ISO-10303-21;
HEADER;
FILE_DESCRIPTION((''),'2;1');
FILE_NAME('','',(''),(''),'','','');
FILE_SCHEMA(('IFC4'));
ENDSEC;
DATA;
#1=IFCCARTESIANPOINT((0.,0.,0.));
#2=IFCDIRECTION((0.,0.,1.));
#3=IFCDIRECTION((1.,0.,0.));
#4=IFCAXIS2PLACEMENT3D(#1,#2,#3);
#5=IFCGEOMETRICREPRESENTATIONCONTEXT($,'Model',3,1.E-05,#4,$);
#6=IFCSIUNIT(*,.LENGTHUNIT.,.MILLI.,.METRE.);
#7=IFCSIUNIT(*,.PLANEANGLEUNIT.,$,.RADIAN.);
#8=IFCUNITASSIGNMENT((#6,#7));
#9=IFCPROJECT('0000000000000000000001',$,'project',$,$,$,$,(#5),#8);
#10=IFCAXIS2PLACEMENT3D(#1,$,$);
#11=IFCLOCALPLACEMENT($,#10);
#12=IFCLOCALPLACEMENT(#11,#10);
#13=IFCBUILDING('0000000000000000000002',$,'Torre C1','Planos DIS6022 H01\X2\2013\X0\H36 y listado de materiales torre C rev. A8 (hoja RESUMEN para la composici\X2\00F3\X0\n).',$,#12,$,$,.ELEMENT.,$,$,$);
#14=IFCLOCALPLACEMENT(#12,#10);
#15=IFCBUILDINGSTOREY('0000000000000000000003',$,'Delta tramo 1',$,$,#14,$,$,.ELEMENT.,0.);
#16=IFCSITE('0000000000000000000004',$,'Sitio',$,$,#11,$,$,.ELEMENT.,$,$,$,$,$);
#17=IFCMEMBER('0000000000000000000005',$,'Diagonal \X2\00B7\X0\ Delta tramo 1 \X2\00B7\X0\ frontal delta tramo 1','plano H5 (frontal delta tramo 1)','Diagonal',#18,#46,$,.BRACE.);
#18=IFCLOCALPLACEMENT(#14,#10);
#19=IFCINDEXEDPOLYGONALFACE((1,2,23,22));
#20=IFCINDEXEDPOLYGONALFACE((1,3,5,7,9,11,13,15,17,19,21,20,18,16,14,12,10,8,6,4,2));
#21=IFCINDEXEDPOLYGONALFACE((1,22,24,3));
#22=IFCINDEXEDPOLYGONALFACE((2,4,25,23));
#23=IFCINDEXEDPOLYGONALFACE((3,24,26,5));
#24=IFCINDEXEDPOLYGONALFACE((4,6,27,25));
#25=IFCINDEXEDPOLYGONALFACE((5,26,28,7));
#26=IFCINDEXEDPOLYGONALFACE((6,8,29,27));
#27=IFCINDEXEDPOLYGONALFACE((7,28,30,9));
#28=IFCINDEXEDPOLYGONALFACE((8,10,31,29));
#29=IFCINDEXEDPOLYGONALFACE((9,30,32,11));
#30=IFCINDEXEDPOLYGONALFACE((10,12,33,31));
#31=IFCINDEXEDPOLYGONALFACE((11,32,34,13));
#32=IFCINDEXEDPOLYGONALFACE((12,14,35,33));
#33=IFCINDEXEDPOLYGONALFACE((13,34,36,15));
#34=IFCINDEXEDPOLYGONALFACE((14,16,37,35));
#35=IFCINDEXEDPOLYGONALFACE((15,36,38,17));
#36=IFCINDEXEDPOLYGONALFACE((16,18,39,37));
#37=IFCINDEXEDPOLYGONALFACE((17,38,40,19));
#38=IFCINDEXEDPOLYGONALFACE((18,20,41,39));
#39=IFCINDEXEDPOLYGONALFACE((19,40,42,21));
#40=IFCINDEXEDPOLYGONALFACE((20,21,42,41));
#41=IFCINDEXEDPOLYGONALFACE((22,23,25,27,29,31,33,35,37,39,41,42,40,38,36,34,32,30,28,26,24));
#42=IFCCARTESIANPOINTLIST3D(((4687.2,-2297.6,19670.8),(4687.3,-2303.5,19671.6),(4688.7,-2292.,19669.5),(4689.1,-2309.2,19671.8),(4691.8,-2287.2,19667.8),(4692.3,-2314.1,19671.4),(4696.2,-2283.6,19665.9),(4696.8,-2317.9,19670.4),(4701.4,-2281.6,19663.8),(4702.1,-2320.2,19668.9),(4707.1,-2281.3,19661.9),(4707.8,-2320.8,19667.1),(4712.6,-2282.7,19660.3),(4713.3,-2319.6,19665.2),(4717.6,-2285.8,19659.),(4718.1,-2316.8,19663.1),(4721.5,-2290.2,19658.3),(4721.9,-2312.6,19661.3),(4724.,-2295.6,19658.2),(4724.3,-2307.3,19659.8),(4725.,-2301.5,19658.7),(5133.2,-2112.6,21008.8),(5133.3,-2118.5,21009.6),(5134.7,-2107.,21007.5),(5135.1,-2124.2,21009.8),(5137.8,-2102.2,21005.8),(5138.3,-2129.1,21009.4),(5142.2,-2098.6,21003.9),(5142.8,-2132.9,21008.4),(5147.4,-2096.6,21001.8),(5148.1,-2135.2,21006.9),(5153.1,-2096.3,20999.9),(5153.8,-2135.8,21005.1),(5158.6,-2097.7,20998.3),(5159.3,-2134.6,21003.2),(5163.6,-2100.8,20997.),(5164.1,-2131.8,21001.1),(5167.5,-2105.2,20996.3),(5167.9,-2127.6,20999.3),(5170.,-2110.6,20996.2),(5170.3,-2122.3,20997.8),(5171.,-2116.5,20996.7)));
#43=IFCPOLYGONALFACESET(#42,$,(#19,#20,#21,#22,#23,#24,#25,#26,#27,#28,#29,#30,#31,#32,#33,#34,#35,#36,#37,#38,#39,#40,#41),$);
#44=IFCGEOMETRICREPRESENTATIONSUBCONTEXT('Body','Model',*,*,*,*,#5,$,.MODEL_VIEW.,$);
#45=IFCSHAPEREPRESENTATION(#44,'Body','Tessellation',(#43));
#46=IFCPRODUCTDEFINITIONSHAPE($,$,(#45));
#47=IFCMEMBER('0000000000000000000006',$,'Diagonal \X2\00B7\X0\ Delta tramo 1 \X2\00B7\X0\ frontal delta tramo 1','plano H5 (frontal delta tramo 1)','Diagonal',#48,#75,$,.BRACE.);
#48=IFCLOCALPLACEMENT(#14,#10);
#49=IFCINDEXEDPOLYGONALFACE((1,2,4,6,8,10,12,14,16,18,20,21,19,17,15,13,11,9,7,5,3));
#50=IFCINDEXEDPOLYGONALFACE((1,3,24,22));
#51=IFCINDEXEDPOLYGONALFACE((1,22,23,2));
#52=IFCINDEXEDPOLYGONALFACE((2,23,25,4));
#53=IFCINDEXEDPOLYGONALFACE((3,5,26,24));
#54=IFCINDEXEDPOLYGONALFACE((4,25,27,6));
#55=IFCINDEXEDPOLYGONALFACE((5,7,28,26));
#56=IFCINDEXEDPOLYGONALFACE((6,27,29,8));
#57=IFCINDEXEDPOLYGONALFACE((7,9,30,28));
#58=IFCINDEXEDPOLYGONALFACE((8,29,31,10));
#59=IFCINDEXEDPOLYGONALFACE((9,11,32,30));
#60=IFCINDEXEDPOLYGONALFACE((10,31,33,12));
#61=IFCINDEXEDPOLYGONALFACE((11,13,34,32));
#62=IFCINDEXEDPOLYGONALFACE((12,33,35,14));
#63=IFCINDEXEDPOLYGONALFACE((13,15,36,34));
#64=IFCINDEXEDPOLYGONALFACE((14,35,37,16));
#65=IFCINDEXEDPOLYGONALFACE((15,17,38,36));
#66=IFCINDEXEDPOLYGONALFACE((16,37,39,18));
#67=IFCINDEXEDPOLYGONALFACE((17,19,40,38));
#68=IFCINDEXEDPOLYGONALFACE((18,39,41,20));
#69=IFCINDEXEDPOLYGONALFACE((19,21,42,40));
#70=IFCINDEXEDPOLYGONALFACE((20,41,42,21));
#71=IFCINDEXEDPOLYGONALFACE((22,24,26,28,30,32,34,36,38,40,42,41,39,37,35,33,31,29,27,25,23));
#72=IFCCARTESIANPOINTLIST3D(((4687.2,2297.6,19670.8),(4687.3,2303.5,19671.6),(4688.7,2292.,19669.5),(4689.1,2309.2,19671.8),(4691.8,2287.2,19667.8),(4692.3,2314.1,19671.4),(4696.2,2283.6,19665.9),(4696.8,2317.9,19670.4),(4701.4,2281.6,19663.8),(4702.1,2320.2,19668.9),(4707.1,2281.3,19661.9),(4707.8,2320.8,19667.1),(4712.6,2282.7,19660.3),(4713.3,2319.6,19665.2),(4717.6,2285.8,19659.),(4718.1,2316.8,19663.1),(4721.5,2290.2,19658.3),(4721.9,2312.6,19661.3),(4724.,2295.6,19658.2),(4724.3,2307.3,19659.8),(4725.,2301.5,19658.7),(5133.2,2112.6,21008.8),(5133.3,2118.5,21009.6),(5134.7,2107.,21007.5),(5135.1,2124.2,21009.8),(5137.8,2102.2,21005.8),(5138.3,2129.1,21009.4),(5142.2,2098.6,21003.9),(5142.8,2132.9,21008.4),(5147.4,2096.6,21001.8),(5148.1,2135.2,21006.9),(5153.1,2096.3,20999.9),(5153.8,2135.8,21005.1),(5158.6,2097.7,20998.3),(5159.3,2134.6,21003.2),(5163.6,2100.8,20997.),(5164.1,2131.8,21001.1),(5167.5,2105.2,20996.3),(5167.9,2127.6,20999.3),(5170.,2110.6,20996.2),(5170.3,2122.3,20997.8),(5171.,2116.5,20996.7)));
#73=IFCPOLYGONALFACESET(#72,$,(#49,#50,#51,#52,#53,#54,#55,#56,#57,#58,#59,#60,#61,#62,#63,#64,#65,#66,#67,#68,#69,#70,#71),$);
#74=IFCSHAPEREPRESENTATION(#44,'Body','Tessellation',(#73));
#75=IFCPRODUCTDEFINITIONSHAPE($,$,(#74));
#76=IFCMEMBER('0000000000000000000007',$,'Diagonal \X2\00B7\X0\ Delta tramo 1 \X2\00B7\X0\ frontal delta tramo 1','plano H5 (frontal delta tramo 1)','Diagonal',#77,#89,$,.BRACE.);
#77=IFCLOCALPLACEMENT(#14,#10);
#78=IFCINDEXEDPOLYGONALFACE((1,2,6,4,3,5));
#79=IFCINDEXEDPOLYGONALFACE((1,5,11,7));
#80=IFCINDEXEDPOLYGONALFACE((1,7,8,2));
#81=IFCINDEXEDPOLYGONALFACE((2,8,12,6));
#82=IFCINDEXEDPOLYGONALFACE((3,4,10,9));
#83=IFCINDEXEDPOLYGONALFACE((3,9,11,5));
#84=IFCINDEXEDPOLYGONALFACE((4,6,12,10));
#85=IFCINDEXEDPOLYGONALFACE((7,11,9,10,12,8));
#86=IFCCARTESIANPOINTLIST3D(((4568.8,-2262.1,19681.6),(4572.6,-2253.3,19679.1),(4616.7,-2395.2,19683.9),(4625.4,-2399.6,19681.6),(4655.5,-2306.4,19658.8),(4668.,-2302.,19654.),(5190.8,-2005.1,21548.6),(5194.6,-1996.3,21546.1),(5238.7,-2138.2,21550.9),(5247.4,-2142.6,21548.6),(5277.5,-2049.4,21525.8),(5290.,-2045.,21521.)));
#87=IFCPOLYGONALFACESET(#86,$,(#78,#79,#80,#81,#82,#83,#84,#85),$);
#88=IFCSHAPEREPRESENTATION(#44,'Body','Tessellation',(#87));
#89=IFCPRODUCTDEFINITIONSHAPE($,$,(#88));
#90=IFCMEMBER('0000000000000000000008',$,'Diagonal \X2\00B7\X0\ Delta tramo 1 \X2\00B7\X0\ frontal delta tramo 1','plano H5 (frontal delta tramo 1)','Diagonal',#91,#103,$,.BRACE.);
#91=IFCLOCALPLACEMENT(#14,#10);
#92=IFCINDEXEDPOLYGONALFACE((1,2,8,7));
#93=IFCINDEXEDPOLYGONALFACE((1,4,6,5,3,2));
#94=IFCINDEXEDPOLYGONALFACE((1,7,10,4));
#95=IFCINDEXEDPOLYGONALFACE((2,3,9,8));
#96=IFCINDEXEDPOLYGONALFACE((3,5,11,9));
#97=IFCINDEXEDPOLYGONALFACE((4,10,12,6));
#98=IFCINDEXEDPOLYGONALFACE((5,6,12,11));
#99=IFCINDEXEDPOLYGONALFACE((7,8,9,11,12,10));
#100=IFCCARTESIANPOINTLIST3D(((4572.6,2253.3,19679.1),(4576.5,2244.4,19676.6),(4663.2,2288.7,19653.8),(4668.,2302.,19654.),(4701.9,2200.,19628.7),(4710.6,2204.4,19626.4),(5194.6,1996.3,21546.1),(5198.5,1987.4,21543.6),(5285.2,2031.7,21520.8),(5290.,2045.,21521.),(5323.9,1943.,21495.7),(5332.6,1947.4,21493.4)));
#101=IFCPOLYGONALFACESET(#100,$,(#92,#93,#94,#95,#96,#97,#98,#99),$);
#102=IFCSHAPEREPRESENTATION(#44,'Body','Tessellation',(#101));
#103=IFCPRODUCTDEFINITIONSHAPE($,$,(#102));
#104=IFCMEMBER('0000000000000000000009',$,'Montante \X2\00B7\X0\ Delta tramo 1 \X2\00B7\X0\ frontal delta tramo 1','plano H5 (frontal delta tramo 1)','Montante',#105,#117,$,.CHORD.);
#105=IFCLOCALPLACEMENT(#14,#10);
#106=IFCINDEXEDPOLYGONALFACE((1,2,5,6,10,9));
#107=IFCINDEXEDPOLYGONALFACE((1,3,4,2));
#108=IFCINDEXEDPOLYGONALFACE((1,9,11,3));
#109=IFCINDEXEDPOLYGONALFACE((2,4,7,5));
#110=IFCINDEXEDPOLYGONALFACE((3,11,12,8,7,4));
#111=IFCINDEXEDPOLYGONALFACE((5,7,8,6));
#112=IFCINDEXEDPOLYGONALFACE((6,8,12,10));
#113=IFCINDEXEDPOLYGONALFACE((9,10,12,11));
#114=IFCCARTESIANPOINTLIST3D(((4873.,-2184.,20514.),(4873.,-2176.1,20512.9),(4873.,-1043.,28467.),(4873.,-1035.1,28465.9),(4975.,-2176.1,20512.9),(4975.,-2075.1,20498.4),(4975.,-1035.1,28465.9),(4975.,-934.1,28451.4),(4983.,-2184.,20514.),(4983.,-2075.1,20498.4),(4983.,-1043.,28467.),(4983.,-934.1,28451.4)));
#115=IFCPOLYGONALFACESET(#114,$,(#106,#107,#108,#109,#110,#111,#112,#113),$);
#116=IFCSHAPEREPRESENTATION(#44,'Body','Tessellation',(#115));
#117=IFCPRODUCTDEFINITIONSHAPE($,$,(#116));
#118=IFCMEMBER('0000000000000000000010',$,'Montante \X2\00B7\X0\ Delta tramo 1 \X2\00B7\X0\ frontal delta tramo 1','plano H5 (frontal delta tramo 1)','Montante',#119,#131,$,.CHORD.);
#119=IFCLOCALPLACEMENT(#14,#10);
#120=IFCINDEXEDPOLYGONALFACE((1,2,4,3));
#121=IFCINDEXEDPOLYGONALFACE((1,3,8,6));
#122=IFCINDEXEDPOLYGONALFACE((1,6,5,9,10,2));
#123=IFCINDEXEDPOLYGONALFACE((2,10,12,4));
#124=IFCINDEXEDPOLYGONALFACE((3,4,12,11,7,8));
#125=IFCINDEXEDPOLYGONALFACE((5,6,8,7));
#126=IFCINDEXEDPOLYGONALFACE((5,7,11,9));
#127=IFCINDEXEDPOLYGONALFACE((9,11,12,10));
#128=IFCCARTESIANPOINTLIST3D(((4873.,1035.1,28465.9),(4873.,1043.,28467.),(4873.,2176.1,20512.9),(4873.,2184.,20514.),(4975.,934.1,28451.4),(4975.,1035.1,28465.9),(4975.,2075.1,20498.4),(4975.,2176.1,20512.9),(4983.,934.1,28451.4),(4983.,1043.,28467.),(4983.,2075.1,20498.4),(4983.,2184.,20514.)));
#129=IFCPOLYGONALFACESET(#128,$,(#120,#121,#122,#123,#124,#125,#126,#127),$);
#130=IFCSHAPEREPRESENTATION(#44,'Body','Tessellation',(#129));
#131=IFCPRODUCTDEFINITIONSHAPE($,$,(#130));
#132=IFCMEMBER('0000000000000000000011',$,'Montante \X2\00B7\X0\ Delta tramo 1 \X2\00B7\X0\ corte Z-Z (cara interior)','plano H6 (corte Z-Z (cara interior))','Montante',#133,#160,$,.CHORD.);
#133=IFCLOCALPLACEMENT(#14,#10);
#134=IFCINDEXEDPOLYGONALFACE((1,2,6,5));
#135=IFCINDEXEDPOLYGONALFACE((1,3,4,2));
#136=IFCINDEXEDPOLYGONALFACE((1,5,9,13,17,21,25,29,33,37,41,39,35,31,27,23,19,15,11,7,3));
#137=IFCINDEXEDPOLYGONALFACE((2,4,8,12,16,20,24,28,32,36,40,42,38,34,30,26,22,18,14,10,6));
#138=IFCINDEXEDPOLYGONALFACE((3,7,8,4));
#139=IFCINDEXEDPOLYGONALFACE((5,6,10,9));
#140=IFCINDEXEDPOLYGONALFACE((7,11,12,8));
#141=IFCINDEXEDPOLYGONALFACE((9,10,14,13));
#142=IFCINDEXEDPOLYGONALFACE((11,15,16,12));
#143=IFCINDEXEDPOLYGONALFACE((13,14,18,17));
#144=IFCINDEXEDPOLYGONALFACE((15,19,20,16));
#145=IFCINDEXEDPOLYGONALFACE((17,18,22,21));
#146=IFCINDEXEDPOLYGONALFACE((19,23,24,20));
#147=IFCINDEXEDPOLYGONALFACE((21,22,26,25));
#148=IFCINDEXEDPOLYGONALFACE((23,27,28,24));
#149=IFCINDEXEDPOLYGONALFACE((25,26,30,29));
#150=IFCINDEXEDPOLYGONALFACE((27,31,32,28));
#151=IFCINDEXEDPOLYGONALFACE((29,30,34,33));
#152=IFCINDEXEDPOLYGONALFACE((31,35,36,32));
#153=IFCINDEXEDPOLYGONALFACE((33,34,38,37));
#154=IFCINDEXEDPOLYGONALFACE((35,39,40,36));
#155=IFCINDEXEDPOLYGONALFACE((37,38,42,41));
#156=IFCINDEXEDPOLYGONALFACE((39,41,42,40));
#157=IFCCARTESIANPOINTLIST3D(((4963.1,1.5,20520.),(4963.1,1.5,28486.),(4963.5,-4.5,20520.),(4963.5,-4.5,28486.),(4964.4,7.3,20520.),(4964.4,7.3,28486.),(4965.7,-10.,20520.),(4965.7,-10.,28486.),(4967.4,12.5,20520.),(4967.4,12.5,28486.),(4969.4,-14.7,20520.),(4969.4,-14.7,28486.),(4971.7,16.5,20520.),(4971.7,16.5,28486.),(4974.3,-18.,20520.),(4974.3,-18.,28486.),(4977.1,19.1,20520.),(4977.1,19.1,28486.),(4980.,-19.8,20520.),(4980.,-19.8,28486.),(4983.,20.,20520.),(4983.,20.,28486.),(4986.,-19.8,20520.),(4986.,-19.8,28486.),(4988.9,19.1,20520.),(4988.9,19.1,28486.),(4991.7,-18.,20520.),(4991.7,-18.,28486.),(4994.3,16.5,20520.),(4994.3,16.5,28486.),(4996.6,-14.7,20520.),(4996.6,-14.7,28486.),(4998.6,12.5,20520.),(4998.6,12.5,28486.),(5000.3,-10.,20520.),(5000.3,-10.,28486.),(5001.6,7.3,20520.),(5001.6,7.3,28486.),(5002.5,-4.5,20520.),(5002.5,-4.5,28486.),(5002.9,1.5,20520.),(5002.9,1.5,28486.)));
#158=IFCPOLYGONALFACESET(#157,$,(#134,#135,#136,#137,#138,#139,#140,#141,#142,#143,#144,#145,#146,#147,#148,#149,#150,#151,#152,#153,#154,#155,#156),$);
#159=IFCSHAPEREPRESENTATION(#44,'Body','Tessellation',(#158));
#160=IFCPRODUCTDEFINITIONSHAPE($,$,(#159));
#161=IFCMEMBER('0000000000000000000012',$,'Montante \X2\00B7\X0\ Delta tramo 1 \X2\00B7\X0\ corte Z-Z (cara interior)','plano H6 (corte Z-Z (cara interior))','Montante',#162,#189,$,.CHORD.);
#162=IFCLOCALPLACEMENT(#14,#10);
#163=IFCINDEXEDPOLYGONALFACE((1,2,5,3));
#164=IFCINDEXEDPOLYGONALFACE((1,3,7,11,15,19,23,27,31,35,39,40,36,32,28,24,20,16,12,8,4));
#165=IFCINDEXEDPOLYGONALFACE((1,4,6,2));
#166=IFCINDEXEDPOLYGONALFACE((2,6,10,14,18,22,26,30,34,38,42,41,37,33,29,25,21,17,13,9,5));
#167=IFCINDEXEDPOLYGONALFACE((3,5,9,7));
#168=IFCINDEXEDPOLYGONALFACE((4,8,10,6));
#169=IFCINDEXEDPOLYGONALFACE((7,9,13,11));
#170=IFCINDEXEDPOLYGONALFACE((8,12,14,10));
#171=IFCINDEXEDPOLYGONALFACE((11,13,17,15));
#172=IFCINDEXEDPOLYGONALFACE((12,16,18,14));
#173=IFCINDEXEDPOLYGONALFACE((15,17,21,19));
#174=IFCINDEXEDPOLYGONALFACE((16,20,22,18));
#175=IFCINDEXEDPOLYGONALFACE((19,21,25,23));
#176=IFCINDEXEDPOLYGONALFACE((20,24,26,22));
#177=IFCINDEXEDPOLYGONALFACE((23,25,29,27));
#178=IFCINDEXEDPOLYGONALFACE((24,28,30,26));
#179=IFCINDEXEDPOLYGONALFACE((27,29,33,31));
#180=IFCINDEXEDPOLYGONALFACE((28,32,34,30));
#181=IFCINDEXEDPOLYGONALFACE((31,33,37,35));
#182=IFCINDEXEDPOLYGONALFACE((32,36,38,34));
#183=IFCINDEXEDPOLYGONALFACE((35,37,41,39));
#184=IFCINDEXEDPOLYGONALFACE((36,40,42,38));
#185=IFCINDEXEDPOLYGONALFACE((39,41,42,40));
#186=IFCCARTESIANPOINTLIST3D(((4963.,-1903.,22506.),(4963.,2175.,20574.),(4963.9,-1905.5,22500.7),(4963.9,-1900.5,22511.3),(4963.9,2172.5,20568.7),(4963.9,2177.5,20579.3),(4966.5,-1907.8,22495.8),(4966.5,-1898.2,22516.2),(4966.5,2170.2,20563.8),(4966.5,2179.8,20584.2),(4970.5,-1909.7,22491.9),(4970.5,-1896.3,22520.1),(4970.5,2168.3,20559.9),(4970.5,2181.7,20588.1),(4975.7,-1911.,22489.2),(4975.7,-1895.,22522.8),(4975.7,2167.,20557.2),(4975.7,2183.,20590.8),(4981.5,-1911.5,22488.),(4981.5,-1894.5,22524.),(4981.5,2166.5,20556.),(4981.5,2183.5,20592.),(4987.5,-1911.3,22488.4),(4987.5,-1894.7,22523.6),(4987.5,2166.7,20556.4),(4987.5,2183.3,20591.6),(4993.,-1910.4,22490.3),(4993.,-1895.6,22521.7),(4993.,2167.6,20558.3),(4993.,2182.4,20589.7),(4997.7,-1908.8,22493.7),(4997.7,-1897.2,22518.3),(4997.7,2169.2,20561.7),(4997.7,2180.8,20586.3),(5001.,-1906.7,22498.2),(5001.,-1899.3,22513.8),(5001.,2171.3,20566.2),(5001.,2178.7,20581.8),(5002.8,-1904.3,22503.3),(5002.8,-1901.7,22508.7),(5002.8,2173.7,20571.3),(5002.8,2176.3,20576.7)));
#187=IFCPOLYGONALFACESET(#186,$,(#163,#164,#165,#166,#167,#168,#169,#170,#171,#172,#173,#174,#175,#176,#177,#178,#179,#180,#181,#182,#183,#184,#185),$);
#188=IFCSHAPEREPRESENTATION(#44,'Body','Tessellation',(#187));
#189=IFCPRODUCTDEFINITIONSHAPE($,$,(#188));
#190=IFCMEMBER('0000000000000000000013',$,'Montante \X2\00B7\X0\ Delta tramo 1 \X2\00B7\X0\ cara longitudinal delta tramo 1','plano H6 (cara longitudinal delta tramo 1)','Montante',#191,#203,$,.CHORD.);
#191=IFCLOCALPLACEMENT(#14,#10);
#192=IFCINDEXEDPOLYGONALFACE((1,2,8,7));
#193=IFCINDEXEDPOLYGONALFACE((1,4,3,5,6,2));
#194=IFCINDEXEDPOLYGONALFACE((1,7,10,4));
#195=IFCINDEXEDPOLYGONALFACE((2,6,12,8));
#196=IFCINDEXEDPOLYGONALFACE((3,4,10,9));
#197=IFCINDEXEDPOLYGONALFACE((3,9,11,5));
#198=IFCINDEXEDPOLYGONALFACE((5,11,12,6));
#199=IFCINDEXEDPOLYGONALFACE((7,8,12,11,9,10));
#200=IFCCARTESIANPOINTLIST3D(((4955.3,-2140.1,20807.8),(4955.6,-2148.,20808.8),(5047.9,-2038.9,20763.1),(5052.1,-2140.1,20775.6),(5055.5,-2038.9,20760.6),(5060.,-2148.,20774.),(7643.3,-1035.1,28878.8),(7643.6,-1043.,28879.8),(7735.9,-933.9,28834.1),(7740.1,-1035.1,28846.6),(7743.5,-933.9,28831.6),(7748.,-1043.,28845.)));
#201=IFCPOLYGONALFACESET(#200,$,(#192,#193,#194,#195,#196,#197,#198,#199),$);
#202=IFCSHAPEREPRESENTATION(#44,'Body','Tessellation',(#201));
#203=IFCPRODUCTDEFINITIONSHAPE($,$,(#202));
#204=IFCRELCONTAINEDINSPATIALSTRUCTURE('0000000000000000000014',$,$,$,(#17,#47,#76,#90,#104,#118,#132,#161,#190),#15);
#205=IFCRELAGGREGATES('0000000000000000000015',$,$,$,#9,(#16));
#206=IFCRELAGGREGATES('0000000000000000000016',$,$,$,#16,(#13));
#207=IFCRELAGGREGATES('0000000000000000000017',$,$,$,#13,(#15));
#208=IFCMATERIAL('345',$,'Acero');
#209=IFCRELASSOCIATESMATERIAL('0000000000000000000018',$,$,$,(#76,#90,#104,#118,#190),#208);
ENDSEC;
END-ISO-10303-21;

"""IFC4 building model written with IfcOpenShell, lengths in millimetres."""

from ifc_helpers import new_model, si_unit, frame, frame_2d, origin, origin_with_axes, place, context, subcontext, project, spatial, circle, l_section, extrude, material, element, save


model = new_model("IFC4")

# Units and contexts
model_context = context("Model", 3, precision=1e-05, world=origin_with_axes())
body_context = subcontext(model_context, "Body", "Model", "MODEL_VIEW")
ifc_project = project(units=[si_unit("LENGTHUNIT", "METRE", prefix="MILLI"), si_unit("PLANEANGLEUNIT", "RADIAN")], contexts=[model_context])

# Site, building, storey
site_placement = place(None, origin())
site = spatial("IfcSite", under=ifc_project, at=site_placement, Name="Sitio", CompositionType="ELEMENT")
building_placement = place(site_placement, origin())
building = spatial("IfcBuilding", under=site, at=building_placement, Name="Torre C1", Description="Planos DIS6022 H01–H36 y listado de materiales torre C rev. A8 (hoja RESUMEN para la composición).", CompositionType="ELEMENT")
storey_placement = place(building_placement, origin())
storey = spatial("IfcBuildingStorey", under=building, at=storey_placement, Name="Delta tramo 1", CompositionType="ELEMENT", Elevation=0.0)

# Members
for number, where, z_axis, x_axis, name in (
    (1, (4706.0, -2301.0, 19665.0), (0.313542, 0.130057, 0.940626), (-0.863292, 0.451616, 0.225321), "Diagonal · Delta tramo 1 · frontal delta tramo 1"),
    (2, (4706.0, 2301.0, 19665.0), (0.313542, -0.130057, 0.940626), (-0.863292, -0.451616, 0.225321), "Diagonal · Delta tramo 1 · frontal delta tramo 1"),
):
    element("IfcMember", number, at=place(storey_placement, frame(where, z_axis=z_axis, x_axis=x_axis)), inside=storey, Name=name, Description="plano H5 (frontal delta tramo 1)", ObjectType="Diagonal", PredefinedType="BRACE", context=body_context, shape_type="SweptSolid", body=[
        extrude(circle(Radius=20.0), None, (0.0, 0.0, 1.0), 1422.5),
    ])
ifc_material_1 = material(Name="345", Category="Acero")
for number, where, z_axis, x_axis, name in (
    (3, (4668.0, -2302.0, 19654.0), (0.313414, 0.129497, 0.940746), (-0.867067, 0.443015, 0.227885), "Diagonal · Delta tramo 1 · frontal delta tramo 1"),
    (4, (4668.0, 2302.0, 19654.0), (0.313414, -0.129497, 0.940746), (-0.867067, -0.443015, 0.227885), "Diagonal · Delta tramo 1 · frontal delta tramo 1"),
):
    element("IfcMember", number, at=place(storey_placement, frame(where, z_axis=z_axis, x_axis=x_axis)), inside=storey, material=ifc_material_1, Name=name, Description="plano H5 (frontal delta tramo 1)", ObjectType="Diagonal", PredefinedType="BRACE", context=body_context, shape_type="SweptSolid", body=[
        extrude(l_section(Depth=110.0, Width=110.0, Thickness=10.0, at=frame_2d((55.0, 55.0))), None, (0.0, 0.0, 1.0), 1984.6),
    ])
for number, where, z_axis, x_axis, name in (
    (5, (4983.0, -2184.0, 20514.0), (0.0, 0.142014, 0.989865), (0.0, 0.989865, -0.142014), "Montante · Delta tramo 1 · frontal delta tramo 1"),
    (6, (4983.0, 2184.0, 20514.0), (0.0, -0.142014, 0.989865), (-1.0, 0.0, 0.0), "Montante · Delta tramo 1 · frontal delta tramo 1"),
):
    element("IfcMember", number, at=place(storey_placement, frame(where, z_axis=z_axis, x_axis=x_axis)), inside=storey, material=ifc_material_1, Name=name, Description="plano H5 (frontal delta tramo 1)", ObjectType="Montante", PredefinedType="CHORD", context=body_context, shape_type="SweptSolid", body=[
        extrude(l_section(Depth=110.0, Width=110.0, Thickness=8.0, at=frame_2d((55.0, 55.0))), None, (0.0, 0.0, 1.0), 8034.4),
    ])
member_1_placement = place(storey_placement, frame((4983.0, 0.0, 20520.0), z_axis=(0.0, 0.0, 1.0), x_axis=(0.0, 1.0, 0.0)))
element("IfcMember", 7, at=member_1_placement, inside=storey, Name="Montante · Delta tramo 1 · corte Z-Z (cara interior)", Description="plano H6 (corte Z-Z (cara interior))", ObjectType="Montante", PredefinedType="CHORD", context=body_context, shape_type="SweptSolid", body=[
    extrude(circle(Radius=20.0), None, (0.0, 0.0, 1.0), 7966.0),
])
member_2_placement = place(storey_placement, frame((4983.0, 2175.0, 20574.0), z_axis=(0.0, -0.903711, 0.428144), x_axis=(-1.0, 0.0, 0.0)))
element("IfcMember", 8, at=member_2_placement, inside=storey, Name="Montante · Delta tramo 1 · corte Z-Z (cara interior)", Description="plano H6 (corte Z-Z (cara interior))", ObjectType="Montante", PredefinedType="CHORD", context=body_context, shape_type="SweptSolid", body=[
    extrude(circle(Radius=20.0), None, (0.0, 0.0, 1.0), 4512.5),
])
member_3_placement = place(storey_placement, frame((5060.0, -2148.0, 20774.0), z_axis=(0.313348, 0.128813, 0.940861), x_axis=(-0.040703, 0.991669, -0.122214)))
element("IfcMember", 9, at=member_3_placement, inside=storey, material=ifc_material_1, Name="Montante · Delta tramo 1 · cara longitudinal delta tramo 1", Description="plano H6 (cara longitudinal delta tramo 1)", ObjectType="Montante", PredefinedType="CHORD", context=body_context, shape_type="SweptSolid", body=[
    extrude(l_section(Depth=110.0, Width=110.0, Thickness=8.0, at=frame_2d((55.0, 55.0))), None, (0.0, 0.0, 1.0), 8578.3),
])

save(model, "model.ifc")
